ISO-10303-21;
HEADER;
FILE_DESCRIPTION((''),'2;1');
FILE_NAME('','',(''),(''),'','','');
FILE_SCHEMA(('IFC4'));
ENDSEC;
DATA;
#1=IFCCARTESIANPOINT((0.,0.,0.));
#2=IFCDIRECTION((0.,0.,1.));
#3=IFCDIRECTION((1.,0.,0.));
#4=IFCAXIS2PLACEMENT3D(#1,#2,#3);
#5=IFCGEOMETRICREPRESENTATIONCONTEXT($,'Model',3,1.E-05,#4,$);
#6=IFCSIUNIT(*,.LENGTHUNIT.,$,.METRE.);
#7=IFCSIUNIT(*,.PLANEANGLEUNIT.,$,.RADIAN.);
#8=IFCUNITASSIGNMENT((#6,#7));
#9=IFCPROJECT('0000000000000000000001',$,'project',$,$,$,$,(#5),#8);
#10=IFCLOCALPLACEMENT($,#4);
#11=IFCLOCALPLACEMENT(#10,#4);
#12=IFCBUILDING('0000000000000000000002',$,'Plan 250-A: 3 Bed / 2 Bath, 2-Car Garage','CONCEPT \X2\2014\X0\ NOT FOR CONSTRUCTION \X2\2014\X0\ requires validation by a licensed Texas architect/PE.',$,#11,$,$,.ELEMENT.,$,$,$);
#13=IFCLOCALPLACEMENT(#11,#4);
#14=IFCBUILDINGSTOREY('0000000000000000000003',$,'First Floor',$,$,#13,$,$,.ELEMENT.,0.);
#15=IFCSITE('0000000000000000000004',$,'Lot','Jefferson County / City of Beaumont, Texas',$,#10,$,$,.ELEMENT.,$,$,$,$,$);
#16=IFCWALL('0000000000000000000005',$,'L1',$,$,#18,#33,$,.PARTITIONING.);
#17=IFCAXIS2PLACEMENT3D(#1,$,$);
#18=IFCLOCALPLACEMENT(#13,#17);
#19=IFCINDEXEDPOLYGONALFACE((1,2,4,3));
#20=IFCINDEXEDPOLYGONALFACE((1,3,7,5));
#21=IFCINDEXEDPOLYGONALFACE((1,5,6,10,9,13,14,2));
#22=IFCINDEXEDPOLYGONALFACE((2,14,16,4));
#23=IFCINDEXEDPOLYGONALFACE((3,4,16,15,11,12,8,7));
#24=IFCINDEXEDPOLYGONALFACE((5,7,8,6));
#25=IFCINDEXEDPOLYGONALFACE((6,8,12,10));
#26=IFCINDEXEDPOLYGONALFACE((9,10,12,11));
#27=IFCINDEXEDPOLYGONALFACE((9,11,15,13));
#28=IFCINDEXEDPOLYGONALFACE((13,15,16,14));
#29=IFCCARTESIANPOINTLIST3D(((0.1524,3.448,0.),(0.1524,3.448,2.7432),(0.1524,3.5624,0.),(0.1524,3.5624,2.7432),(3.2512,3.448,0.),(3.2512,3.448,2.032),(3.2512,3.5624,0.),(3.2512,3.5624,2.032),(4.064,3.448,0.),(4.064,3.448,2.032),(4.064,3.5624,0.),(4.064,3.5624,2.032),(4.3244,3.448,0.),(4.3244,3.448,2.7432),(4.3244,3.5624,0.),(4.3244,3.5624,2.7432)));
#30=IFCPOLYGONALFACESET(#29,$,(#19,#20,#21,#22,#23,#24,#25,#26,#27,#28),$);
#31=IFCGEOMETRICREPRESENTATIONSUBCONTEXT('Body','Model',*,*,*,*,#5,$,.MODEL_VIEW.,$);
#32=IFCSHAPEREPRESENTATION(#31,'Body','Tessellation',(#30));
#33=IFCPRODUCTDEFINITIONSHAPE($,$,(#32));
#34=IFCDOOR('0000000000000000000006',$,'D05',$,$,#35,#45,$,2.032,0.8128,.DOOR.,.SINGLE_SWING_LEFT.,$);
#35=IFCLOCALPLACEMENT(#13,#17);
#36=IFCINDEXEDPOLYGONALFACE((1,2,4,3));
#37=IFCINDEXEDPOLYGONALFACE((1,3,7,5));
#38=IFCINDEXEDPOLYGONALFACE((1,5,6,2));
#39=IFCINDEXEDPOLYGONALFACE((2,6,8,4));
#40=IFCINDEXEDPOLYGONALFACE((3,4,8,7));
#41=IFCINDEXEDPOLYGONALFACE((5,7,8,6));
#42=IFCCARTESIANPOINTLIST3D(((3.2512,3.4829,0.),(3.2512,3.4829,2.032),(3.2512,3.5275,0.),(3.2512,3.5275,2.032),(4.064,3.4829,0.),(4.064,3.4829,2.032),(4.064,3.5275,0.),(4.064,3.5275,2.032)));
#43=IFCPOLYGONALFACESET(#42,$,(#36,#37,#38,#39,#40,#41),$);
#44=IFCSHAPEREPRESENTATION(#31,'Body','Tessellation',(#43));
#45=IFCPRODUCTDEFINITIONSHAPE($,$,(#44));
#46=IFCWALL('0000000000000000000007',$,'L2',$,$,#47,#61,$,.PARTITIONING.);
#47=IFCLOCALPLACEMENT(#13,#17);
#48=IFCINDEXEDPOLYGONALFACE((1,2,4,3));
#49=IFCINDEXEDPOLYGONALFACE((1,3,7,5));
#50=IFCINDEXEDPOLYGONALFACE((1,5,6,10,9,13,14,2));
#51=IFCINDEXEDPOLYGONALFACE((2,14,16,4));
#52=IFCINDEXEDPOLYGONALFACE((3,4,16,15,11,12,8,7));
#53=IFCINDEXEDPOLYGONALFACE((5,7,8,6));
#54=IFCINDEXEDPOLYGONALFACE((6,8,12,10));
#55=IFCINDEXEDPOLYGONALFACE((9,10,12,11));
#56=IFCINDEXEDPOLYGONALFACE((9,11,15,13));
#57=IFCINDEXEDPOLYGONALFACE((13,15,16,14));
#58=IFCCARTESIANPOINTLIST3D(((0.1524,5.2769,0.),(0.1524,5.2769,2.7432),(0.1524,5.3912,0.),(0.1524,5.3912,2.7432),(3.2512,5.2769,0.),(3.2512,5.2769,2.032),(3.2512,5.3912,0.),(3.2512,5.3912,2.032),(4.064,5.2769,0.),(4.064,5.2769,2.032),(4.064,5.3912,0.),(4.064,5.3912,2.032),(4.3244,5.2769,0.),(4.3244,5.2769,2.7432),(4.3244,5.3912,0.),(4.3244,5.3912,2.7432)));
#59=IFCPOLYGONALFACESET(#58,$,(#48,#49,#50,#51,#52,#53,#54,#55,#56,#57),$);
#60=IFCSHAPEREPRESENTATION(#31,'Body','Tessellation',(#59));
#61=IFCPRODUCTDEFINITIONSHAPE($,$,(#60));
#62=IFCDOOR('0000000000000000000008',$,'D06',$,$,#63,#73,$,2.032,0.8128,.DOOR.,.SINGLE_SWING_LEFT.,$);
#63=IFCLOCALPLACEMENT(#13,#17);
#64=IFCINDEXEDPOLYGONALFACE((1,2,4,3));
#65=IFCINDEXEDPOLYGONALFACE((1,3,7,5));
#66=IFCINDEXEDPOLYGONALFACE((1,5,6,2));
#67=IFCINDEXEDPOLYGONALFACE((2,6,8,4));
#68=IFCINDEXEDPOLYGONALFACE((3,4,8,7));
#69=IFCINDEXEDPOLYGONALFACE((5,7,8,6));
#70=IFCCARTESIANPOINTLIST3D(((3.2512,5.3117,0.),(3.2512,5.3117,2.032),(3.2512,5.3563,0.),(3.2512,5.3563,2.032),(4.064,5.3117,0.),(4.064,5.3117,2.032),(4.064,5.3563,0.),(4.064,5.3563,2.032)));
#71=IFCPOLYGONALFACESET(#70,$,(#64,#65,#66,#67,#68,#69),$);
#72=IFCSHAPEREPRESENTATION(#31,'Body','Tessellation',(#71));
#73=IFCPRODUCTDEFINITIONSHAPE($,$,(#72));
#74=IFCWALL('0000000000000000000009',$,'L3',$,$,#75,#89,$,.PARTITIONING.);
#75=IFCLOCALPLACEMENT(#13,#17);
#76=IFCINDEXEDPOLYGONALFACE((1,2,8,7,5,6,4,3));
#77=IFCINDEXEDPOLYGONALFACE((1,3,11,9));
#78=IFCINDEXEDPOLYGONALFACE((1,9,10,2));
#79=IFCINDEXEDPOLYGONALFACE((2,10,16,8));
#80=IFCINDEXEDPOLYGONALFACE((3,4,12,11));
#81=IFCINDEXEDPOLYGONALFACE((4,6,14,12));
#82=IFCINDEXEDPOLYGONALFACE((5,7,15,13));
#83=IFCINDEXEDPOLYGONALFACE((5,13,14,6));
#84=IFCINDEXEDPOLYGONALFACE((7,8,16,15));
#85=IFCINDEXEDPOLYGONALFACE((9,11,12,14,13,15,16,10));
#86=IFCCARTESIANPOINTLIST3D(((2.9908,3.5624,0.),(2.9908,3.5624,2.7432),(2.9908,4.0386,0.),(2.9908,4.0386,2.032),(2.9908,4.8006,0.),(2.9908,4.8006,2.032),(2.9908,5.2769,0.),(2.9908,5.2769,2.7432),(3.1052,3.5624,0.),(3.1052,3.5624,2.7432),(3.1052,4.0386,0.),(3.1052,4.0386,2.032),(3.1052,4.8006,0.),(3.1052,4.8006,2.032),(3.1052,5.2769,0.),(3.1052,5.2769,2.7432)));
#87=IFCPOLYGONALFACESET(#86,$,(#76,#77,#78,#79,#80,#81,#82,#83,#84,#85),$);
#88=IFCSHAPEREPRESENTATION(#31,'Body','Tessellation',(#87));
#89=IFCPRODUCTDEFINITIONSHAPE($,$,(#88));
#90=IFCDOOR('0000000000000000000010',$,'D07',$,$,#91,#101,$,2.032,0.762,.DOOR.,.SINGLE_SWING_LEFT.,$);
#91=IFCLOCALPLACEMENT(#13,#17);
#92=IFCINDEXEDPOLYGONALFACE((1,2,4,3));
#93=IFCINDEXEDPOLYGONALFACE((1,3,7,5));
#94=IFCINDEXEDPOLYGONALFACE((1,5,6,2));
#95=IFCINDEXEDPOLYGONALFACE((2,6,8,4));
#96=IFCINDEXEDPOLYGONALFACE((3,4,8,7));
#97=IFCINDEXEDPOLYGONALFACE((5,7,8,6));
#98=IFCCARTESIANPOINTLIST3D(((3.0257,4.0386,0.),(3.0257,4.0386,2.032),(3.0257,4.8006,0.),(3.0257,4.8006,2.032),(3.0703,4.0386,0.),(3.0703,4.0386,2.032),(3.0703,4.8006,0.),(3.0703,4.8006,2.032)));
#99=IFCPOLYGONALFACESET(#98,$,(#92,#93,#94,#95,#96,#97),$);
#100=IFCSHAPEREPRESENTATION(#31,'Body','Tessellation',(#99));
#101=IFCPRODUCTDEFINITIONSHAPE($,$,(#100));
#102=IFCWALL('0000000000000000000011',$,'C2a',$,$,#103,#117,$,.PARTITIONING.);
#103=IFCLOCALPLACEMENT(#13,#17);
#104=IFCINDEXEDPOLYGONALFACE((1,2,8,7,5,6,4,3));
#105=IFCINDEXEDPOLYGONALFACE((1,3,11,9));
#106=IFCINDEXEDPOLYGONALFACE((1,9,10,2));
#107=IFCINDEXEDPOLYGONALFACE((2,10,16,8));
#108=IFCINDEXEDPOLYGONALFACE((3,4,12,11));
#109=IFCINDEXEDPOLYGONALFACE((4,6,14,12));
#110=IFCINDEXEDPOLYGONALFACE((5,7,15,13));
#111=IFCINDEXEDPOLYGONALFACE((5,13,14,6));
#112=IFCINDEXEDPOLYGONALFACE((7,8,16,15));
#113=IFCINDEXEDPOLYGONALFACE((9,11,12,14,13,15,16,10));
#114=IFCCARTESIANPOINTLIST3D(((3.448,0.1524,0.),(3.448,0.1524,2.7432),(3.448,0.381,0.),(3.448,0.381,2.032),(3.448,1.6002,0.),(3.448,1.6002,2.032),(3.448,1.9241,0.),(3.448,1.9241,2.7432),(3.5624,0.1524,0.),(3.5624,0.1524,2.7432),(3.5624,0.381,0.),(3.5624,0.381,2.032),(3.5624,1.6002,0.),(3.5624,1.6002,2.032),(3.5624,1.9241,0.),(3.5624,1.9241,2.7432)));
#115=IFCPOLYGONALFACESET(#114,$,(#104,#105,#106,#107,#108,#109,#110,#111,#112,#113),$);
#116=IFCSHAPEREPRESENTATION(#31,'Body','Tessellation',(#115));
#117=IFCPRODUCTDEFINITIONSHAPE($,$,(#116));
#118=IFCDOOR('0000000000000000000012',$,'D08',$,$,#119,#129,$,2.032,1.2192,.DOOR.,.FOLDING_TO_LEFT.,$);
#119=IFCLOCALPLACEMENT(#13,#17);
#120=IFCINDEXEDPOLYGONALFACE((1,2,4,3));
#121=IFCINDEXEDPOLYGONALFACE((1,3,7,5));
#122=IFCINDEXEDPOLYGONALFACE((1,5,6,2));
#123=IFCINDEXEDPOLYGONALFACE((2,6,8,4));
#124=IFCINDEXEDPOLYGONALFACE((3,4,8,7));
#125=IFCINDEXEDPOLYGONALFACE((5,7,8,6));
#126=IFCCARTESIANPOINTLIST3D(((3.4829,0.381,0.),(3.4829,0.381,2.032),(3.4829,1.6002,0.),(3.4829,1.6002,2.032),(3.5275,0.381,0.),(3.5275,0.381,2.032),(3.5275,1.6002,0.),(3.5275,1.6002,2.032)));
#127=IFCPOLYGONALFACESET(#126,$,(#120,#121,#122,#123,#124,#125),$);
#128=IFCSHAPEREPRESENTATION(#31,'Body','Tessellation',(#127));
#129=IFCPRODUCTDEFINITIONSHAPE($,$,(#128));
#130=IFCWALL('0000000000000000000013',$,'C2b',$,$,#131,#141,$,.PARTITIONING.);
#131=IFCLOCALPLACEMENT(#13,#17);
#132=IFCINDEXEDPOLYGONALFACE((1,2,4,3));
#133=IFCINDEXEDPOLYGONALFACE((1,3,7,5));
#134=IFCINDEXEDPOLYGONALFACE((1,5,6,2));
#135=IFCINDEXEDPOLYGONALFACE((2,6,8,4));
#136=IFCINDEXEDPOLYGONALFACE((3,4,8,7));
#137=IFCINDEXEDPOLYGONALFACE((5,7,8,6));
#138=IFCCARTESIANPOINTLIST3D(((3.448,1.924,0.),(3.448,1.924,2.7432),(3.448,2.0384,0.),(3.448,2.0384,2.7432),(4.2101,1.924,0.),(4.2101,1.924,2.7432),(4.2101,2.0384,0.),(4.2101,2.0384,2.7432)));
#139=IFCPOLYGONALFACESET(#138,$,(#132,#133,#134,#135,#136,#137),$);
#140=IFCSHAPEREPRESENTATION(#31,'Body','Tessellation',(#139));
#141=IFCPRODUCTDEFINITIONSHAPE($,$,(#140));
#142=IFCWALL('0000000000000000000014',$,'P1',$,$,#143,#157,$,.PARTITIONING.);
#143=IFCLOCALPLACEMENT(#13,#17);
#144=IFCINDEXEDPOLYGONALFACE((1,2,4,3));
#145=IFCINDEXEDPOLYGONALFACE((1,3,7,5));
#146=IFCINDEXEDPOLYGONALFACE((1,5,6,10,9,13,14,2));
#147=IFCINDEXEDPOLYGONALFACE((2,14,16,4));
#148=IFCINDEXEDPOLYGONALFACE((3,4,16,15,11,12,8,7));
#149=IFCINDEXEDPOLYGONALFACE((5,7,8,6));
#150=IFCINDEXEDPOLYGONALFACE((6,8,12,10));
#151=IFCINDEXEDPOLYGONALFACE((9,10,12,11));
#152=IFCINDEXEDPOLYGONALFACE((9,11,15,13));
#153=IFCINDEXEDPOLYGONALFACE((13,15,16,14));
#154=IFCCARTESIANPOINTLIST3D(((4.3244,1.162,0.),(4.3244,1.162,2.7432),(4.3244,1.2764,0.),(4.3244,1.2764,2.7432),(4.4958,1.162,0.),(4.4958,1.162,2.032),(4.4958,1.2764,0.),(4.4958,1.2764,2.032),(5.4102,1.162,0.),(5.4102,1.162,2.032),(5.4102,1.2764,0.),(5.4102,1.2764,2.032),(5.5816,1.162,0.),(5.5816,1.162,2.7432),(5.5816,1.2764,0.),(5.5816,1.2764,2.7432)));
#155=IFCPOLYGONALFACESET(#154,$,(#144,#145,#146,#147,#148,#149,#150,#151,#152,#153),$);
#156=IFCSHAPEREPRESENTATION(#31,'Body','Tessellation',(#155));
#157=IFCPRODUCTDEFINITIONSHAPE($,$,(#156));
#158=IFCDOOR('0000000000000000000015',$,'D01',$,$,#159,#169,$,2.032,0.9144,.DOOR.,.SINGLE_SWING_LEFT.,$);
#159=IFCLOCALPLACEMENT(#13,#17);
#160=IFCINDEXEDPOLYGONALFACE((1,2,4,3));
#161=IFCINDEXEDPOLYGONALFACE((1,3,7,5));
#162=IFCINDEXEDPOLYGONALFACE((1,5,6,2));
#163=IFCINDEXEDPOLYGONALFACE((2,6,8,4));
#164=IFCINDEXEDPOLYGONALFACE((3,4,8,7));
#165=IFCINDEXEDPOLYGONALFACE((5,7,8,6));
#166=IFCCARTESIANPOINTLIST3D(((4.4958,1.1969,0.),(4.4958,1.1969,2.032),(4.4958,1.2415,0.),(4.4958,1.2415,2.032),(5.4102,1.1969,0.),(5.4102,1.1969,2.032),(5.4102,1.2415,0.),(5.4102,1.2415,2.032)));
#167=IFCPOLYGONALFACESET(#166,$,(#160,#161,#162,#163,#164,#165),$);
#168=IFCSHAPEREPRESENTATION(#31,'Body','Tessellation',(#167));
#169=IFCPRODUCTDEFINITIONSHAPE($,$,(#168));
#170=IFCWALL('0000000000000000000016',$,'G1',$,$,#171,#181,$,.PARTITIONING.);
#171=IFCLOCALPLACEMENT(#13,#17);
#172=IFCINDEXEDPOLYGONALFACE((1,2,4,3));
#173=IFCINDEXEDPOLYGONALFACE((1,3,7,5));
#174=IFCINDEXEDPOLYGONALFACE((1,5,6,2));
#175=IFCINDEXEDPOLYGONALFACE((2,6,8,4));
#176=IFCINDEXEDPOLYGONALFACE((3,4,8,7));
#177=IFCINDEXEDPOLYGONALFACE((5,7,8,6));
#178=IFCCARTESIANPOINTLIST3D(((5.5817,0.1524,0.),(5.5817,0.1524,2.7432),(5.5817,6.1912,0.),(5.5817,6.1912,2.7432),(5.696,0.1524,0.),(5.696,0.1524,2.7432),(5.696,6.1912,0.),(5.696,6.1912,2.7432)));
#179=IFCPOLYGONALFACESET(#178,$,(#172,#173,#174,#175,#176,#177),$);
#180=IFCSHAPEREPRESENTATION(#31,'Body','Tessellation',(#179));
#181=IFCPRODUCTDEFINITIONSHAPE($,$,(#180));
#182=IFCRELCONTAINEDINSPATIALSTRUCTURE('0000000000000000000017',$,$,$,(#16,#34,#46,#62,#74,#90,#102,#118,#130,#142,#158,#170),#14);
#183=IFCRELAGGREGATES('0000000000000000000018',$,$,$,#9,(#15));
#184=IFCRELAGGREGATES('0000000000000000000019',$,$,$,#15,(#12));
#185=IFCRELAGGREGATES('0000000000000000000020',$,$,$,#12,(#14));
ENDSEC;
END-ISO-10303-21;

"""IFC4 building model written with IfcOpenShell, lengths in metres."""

from ifc_helpers import new_model, si_unit, frame, frame_2d, origin_with_axes, place, context, subcontext, project, spatial, rectangle, extrude, element, fill, save


model = new_model("IFC4")

# Units and contexts
model_context = context("Model", 3, precision=1e-05, world=origin_with_axes())
body_context = subcontext(model_context, "Body", "Model", "MODEL_VIEW")
ifc_project = project(units=[si_unit("LENGTHUNIT", "METRE"), si_unit("PLANEANGLEUNIT", "RADIAN")], contexts=[model_context])

# Site, building, storey
site_placement = place(None, origin_with_axes())
site = spatial("IfcSite", under=ifc_project, at=site_placement, Name="Lot", Description="Jefferson County / City of Beaumont, Texas", CompositionType="ELEMENT")
building_placement = place(site_placement, origin_with_axes())
building = spatial("IfcBuilding", under=site, at=building_placement, Name="Plan 250-A: 3 Bed / 2 Bath, 2-Car Garage", Description="CONCEPT — NOT FOR CONSTRUCTION — requires validation by a licensed Texas architect/PE.", CompositionType="ELEMENT")
storey_placement = place(building_placement, origin_with_axes())
storey = spatial("IfcBuildingStorey", under=building, at=storey_placement, Name="First Floor", CompositionType="ELEMENT", Elevation=0.0)

# Walls, openings, doors
wall_1_placement = place(storey_placement, frame((0.1524, 3.5052, 0.0), z_axis=(0.0, 0.0, 1.0), x_axis=(1.0, 0.0, 0.0)))
wall_1 = element("IfcWall", 1, at=wall_1_placement, inside=storey, Name="L1", PredefinedType="PARTITIONING", context=body_context, shape_type="SweptSolid", body=[
    extrude(rectangle(XDim=4.1719, YDim=0.1143, at=frame_2d((2.086, 0.0), x_axis=(1.0, 0.0))), origin_with_axes(), (0.0, 0.0, 1.0), 2.7432),
])
opening_1_placement = place(wall_1_placement, frame((3.0988, 0.0, 0.0), z_axis=(0.0, 0.0, 1.0), x_axis=(1.0, 0.0, 0.0)))
opening_1 = element("IfcOpeningElement", 2, at=opening_1_placement, cuts=wall_1, PredefinedType="OPENING", context=body_context, shape_type="SweptSolid", body=[
    extrude(rectangle(XDim=0.8128, YDim=0.1448, at=frame_2d((0.4064, 0.0), x_axis=(1.0, 0.0))), origin_with_axes(), (0.0, 0.0, 1.0), 2.032),
])
door_1_placement = place(opening_1_placement, origin_with_axes())
door_1 = element("IfcDoor", 3, at=door_1_placement, inside=storey, Name="D05", OperationType="SINGLE_SWING_LEFT", OverallHeight=2.032, OverallWidth=0.8128, PredefinedType="DOOR", context=body_context, shape_type="SweptSolid", body=[
    extrude(rectangle(XDim=0.8128, YDim=0.0445, at=frame_2d((0.4064, 0.0), x_axis=(1.0, 0.0))), origin_with_axes(), (0.0, 0.0, 1.0), 2.032),
])
fill(opening_1, door_1)
wall_2_placement = place(storey_placement, frame((0.1524, 5.334, 0.0), z_axis=(0.0, 0.0, 1.0), x_axis=(1.0, 0.0, 0.0)))
wall_2 = element("IfcWall", 4, at=wall_2_placement, inside=storey, Name="L2", PredefinedType="PARTITIONING", context=body_context, shape_type="SweptSolid", body=[
    extrude(rectangle(XDim=4.1719, YDim=0.1143, at=frame_2d((2.086, 0.0), x_axis=(1.0, 0.0))), origin_with_axes(), (0.0, 0.0, 1.0), 2.7432),
])
opening_2_placement = place(wall_2_placement, frame((3.0988, 0.0, 0.0), z_axis=(0.0, 0.0, 1.0), x_axis=(1.0, 0.0, 0.0)))
opening_2 = element("IfcOpeningElement", 5, at=opening_2_placement, cuts=wall_2, PredefinedType="OPENING", context=body_context, shape_type="SweptSolid", body=[
    extrude(rectangle(XDim=0.8128, YDim=0.1448, at=frame_2d((0.4064, 0.0), x_axis=(1.0, 0.0))), origin_with_axes(), (0.0, 0.0, 1.0), 2.032),
])
door_2_placement = place(opening_2_placement, origin_with_axes())
door_2 = element("IfcDoor", 6, at=door_2_placement, inside=storey, Name="D06", OperationType="SINGLE_SWING_LEFT", OverallHeight=2.032, OverallWidth=0.8128, PredefinedType="DOOR", context=body_context, shape_type="SweptSolid", body=[
    extrude(rectangle(XDim=0.8128, YDim=0.0445, at=frame_2d((0.4064, 0.0), x_axis=(1.0, 0.0))), origin_with_axes(), (0.0, 0.0, 1.0), 2.032),
])
fill(opening_2, door_2)
wall_3_placement = place(storey_placement, frame((3.048, 3.5624, 0.0), z_axis=(0.0, 0.0, 1.0), x_axis=(0.0, 1.0, 0.0)))
wall_3 = element("IfcWall", 7, at=wall_3_placement, inside=storey, Name="L3", PredefinedType="PARTITIONING", context=body_context, shape_type="SweptSolid", body=[
    extrude(rectangle(XDim=1.7145, YDim=0.1143, at=frame_2d((0.8573, 0.0), x_axis=(1.0, 0.0))), origin_with_axes(), (0.0, 0.0, 1.0), 2.7432),
])
opening_3_placement = place(wall_3_placement, frame((0.4763, 0.0, 0.0), z_axis=(0.0, 0.0, 1.0), x_axis=(1.0, 0.0, 0.0)))
opening_3 = element("IfcOpeningElement", 8, at=opening_3_placement, cuts=wall_3, PredefinedType="OPENING", context=body_context, shape_type="SweptSolid", body=[
    extrude(rectangle(XDim=0.762, YDim=0.1448, at=frame_2d((0.381, 0.0), x_axis=(1.0, 0.0))), origin_with_axes(), (0.0, 0.0, 1.0), 2.032),
])
door_3_placement = place(opening_3_placement, origin_with_axes())
door_3 = element("IfcDoor", 9, at=door_3_placement, inside=storey, Name="D07", OperationType="SINGLE_SWING_LEFT", OverallHeight=2.032, OverallWidth=0.762, PredefinedType="DOOR", context=body_context, shape_type="SweptSolid", body=[
    extrude(rectangle(XDim=0.762, YDim=0.0445, at=frame_2d((0.381, 0.0), x_axis=(1.0, 0.0))), origin_with_axes(), (0.0, 0.0, 1.0), 2.032),
])
fill(opening_3, door_3)
wall_4_placement = place(storey_placement, frame((3.5052, 0.1524, 0.0), z_axis=(0.0, 0.0, 1.0), x_axis=(0.0, 1.0, 0.0)))
wall_4 = element("IfcWall", 10, at=wall_4_placement, inside=storey, Name="C2a", PredefinedType="PARTITIONING", context=body_context, shape_type="SweptSolid", body=[
    extrude(rectangle(XDim=1.7717, YDim=0.1143, at=frame_2d((0.8858, 0.0), x_axis=(1.0, 0.0))), origin_with_axes(), (0.0, 0.0, 1.0), 2.7432),
])
opening_4_placement = place(wall_4_placement, frame((0.2286, 0.0, 0.0), z_axis=(0.0, 0.0, 1.0), x_axis=(1.0, 0.0, 0.0)))
opening_4 = element("IfcOpeningElement", 11, at=opening_4_placement, cuts=wall_4, PredefinedType="OPENING", context=body_context, shape_type="SweptSolid", body=[
    extrude(rectangle(XDim=1.2192, YDim=0.1448, at=frame_2d((0.6096, 0.0), x_axis=(1.0, 0.0))), origin_with_axes(), (0.0, 0.0, 1.0), 2.032),
])
door_4_placement = place(opening_4_placement, origin_with_axes())
door_4 = element("IfcDoor", 12, at=door_4_placement, inside=storey, Name="D08", OperationType="FOLDING_TO_LEFT", OverallHeight=2.032, OverallWidth=1.2192, PredefinedType="DOOR", context=body_context, shape_type="SweptSolid", body=[
    extrude(rectangle(XDim=1.2192, YDim=0.0445, at=frame_2d((0.6096, 0.0), x_axis=(1.0, 0.0))), origin_with_axes(), (0.0, 0.0, 1.0), 2.032),
])
fill(opening_4, door_4)

# Wall
wall_5_placement = place(storey_placement, frame((3.4481, 1.9812, 0.0), z_axis=(0.0, 0.0, 1.0), x_axis=(1.0, 0.0, 0.0)))
element("IfcWall", 13, at=wall_5_placement, inside=storey, Name="C2b", PredefinedType="PARTITIONING", context=body_context, shape_type="SweptSolid", body=[
    extrude(rectangle(XDim=0.762, YDim=0.1143, at=frame_2d((0.381, 0.0), x_axis=(1.0, 0.0))), origin_with_axes(), (0.0, 0.0, 1.0), 2.7432),
])

# Wall, opening, door
wall_6_placement = place(storey_placement, frame((4.3243, 1.2192, 0.0), z_axis=(0.0, 0.0, 1.0), x_axis=(1.0, 0.0, 0.0)))
wall_6 = element("IfcWall", 14, at=wall_6_placement, inside=storey, Name="P1", PredefinedType="PARTITIONING", context=body_context, shape_type="SweptSolid", body=[
    extrude(rectangle(XDim=1.2573, YDim=0.1143, at=frame_2d((0.6287, 0.0), x_axis=(1.0, 0.0))), origin_with_axes(), (0.0, 0.0, 1.0), 2.7432),
])
opening_5_placement = place(wall_6_placement, frame((0.1715, 0.0, 0.0), z_axis=(0.0, 0.0, 1.0), x_axis=(1.0, 0.0, 0.0)))
opening_5 = element("IfcOpeningElement", 15, at=opening_5_placement, cuts=wall_6, PredefinedType="OPENING", context=body_context, shape_type="SweptSolid", body=[
    extrude(rectangle(XDim=0.9144, YDim=0.1448, at=frame_2d((0.4572, 0.0), x_axis=(1.0, 0.0))), origin_with_axes(), (0.0, 0.0, 1.0), 2.032),
])
door_5_placement = place(opening_5_placement, origin_with_axes())
door_5 = element("IfcDoor", 16, at=door_5_placement, inside=storey, Name="D01", OperationType="SINGLE_SWING_LEFT", OverallHeight=2.032, OverallWidth=0.9144, PredefinedType="DOOR", context=body_context, shape_type="SweptSolid", body=[
    extrude(rectangle(XDim=0.9144, YDim=0.0445, at=frame_2d((0.4572, 0.0), x_axis=(1.0, 0.0))), origin_with_axes(), (0.0, 0.0, 1.0), 2.032),
])
fill(opening_5, door_5)

# Wall
wall_7_placement = place(storey_placement, frame((5.6388, 0.1524, 0.0), z_axis=(0.0, 0.0, 1.0), x_axis=(0.0, 1.0, 0.0)))
element("IfcWall", 17, at=wall_7_placement, inside=storey, Name="G1", PredefinedType="PARTITIONING", context=body_context, shape_type="SweptSolid", body=[
    extrude(rectangle(XDim=6.0389, YDim=0.1143, at=frame_2d((3.0194, 0.0), x_axis=(1.0, 0.0))), origin_with_axes(), (0.0, 0.0, 1.0), 2.7432),
])

save(model, "model.ifc")
